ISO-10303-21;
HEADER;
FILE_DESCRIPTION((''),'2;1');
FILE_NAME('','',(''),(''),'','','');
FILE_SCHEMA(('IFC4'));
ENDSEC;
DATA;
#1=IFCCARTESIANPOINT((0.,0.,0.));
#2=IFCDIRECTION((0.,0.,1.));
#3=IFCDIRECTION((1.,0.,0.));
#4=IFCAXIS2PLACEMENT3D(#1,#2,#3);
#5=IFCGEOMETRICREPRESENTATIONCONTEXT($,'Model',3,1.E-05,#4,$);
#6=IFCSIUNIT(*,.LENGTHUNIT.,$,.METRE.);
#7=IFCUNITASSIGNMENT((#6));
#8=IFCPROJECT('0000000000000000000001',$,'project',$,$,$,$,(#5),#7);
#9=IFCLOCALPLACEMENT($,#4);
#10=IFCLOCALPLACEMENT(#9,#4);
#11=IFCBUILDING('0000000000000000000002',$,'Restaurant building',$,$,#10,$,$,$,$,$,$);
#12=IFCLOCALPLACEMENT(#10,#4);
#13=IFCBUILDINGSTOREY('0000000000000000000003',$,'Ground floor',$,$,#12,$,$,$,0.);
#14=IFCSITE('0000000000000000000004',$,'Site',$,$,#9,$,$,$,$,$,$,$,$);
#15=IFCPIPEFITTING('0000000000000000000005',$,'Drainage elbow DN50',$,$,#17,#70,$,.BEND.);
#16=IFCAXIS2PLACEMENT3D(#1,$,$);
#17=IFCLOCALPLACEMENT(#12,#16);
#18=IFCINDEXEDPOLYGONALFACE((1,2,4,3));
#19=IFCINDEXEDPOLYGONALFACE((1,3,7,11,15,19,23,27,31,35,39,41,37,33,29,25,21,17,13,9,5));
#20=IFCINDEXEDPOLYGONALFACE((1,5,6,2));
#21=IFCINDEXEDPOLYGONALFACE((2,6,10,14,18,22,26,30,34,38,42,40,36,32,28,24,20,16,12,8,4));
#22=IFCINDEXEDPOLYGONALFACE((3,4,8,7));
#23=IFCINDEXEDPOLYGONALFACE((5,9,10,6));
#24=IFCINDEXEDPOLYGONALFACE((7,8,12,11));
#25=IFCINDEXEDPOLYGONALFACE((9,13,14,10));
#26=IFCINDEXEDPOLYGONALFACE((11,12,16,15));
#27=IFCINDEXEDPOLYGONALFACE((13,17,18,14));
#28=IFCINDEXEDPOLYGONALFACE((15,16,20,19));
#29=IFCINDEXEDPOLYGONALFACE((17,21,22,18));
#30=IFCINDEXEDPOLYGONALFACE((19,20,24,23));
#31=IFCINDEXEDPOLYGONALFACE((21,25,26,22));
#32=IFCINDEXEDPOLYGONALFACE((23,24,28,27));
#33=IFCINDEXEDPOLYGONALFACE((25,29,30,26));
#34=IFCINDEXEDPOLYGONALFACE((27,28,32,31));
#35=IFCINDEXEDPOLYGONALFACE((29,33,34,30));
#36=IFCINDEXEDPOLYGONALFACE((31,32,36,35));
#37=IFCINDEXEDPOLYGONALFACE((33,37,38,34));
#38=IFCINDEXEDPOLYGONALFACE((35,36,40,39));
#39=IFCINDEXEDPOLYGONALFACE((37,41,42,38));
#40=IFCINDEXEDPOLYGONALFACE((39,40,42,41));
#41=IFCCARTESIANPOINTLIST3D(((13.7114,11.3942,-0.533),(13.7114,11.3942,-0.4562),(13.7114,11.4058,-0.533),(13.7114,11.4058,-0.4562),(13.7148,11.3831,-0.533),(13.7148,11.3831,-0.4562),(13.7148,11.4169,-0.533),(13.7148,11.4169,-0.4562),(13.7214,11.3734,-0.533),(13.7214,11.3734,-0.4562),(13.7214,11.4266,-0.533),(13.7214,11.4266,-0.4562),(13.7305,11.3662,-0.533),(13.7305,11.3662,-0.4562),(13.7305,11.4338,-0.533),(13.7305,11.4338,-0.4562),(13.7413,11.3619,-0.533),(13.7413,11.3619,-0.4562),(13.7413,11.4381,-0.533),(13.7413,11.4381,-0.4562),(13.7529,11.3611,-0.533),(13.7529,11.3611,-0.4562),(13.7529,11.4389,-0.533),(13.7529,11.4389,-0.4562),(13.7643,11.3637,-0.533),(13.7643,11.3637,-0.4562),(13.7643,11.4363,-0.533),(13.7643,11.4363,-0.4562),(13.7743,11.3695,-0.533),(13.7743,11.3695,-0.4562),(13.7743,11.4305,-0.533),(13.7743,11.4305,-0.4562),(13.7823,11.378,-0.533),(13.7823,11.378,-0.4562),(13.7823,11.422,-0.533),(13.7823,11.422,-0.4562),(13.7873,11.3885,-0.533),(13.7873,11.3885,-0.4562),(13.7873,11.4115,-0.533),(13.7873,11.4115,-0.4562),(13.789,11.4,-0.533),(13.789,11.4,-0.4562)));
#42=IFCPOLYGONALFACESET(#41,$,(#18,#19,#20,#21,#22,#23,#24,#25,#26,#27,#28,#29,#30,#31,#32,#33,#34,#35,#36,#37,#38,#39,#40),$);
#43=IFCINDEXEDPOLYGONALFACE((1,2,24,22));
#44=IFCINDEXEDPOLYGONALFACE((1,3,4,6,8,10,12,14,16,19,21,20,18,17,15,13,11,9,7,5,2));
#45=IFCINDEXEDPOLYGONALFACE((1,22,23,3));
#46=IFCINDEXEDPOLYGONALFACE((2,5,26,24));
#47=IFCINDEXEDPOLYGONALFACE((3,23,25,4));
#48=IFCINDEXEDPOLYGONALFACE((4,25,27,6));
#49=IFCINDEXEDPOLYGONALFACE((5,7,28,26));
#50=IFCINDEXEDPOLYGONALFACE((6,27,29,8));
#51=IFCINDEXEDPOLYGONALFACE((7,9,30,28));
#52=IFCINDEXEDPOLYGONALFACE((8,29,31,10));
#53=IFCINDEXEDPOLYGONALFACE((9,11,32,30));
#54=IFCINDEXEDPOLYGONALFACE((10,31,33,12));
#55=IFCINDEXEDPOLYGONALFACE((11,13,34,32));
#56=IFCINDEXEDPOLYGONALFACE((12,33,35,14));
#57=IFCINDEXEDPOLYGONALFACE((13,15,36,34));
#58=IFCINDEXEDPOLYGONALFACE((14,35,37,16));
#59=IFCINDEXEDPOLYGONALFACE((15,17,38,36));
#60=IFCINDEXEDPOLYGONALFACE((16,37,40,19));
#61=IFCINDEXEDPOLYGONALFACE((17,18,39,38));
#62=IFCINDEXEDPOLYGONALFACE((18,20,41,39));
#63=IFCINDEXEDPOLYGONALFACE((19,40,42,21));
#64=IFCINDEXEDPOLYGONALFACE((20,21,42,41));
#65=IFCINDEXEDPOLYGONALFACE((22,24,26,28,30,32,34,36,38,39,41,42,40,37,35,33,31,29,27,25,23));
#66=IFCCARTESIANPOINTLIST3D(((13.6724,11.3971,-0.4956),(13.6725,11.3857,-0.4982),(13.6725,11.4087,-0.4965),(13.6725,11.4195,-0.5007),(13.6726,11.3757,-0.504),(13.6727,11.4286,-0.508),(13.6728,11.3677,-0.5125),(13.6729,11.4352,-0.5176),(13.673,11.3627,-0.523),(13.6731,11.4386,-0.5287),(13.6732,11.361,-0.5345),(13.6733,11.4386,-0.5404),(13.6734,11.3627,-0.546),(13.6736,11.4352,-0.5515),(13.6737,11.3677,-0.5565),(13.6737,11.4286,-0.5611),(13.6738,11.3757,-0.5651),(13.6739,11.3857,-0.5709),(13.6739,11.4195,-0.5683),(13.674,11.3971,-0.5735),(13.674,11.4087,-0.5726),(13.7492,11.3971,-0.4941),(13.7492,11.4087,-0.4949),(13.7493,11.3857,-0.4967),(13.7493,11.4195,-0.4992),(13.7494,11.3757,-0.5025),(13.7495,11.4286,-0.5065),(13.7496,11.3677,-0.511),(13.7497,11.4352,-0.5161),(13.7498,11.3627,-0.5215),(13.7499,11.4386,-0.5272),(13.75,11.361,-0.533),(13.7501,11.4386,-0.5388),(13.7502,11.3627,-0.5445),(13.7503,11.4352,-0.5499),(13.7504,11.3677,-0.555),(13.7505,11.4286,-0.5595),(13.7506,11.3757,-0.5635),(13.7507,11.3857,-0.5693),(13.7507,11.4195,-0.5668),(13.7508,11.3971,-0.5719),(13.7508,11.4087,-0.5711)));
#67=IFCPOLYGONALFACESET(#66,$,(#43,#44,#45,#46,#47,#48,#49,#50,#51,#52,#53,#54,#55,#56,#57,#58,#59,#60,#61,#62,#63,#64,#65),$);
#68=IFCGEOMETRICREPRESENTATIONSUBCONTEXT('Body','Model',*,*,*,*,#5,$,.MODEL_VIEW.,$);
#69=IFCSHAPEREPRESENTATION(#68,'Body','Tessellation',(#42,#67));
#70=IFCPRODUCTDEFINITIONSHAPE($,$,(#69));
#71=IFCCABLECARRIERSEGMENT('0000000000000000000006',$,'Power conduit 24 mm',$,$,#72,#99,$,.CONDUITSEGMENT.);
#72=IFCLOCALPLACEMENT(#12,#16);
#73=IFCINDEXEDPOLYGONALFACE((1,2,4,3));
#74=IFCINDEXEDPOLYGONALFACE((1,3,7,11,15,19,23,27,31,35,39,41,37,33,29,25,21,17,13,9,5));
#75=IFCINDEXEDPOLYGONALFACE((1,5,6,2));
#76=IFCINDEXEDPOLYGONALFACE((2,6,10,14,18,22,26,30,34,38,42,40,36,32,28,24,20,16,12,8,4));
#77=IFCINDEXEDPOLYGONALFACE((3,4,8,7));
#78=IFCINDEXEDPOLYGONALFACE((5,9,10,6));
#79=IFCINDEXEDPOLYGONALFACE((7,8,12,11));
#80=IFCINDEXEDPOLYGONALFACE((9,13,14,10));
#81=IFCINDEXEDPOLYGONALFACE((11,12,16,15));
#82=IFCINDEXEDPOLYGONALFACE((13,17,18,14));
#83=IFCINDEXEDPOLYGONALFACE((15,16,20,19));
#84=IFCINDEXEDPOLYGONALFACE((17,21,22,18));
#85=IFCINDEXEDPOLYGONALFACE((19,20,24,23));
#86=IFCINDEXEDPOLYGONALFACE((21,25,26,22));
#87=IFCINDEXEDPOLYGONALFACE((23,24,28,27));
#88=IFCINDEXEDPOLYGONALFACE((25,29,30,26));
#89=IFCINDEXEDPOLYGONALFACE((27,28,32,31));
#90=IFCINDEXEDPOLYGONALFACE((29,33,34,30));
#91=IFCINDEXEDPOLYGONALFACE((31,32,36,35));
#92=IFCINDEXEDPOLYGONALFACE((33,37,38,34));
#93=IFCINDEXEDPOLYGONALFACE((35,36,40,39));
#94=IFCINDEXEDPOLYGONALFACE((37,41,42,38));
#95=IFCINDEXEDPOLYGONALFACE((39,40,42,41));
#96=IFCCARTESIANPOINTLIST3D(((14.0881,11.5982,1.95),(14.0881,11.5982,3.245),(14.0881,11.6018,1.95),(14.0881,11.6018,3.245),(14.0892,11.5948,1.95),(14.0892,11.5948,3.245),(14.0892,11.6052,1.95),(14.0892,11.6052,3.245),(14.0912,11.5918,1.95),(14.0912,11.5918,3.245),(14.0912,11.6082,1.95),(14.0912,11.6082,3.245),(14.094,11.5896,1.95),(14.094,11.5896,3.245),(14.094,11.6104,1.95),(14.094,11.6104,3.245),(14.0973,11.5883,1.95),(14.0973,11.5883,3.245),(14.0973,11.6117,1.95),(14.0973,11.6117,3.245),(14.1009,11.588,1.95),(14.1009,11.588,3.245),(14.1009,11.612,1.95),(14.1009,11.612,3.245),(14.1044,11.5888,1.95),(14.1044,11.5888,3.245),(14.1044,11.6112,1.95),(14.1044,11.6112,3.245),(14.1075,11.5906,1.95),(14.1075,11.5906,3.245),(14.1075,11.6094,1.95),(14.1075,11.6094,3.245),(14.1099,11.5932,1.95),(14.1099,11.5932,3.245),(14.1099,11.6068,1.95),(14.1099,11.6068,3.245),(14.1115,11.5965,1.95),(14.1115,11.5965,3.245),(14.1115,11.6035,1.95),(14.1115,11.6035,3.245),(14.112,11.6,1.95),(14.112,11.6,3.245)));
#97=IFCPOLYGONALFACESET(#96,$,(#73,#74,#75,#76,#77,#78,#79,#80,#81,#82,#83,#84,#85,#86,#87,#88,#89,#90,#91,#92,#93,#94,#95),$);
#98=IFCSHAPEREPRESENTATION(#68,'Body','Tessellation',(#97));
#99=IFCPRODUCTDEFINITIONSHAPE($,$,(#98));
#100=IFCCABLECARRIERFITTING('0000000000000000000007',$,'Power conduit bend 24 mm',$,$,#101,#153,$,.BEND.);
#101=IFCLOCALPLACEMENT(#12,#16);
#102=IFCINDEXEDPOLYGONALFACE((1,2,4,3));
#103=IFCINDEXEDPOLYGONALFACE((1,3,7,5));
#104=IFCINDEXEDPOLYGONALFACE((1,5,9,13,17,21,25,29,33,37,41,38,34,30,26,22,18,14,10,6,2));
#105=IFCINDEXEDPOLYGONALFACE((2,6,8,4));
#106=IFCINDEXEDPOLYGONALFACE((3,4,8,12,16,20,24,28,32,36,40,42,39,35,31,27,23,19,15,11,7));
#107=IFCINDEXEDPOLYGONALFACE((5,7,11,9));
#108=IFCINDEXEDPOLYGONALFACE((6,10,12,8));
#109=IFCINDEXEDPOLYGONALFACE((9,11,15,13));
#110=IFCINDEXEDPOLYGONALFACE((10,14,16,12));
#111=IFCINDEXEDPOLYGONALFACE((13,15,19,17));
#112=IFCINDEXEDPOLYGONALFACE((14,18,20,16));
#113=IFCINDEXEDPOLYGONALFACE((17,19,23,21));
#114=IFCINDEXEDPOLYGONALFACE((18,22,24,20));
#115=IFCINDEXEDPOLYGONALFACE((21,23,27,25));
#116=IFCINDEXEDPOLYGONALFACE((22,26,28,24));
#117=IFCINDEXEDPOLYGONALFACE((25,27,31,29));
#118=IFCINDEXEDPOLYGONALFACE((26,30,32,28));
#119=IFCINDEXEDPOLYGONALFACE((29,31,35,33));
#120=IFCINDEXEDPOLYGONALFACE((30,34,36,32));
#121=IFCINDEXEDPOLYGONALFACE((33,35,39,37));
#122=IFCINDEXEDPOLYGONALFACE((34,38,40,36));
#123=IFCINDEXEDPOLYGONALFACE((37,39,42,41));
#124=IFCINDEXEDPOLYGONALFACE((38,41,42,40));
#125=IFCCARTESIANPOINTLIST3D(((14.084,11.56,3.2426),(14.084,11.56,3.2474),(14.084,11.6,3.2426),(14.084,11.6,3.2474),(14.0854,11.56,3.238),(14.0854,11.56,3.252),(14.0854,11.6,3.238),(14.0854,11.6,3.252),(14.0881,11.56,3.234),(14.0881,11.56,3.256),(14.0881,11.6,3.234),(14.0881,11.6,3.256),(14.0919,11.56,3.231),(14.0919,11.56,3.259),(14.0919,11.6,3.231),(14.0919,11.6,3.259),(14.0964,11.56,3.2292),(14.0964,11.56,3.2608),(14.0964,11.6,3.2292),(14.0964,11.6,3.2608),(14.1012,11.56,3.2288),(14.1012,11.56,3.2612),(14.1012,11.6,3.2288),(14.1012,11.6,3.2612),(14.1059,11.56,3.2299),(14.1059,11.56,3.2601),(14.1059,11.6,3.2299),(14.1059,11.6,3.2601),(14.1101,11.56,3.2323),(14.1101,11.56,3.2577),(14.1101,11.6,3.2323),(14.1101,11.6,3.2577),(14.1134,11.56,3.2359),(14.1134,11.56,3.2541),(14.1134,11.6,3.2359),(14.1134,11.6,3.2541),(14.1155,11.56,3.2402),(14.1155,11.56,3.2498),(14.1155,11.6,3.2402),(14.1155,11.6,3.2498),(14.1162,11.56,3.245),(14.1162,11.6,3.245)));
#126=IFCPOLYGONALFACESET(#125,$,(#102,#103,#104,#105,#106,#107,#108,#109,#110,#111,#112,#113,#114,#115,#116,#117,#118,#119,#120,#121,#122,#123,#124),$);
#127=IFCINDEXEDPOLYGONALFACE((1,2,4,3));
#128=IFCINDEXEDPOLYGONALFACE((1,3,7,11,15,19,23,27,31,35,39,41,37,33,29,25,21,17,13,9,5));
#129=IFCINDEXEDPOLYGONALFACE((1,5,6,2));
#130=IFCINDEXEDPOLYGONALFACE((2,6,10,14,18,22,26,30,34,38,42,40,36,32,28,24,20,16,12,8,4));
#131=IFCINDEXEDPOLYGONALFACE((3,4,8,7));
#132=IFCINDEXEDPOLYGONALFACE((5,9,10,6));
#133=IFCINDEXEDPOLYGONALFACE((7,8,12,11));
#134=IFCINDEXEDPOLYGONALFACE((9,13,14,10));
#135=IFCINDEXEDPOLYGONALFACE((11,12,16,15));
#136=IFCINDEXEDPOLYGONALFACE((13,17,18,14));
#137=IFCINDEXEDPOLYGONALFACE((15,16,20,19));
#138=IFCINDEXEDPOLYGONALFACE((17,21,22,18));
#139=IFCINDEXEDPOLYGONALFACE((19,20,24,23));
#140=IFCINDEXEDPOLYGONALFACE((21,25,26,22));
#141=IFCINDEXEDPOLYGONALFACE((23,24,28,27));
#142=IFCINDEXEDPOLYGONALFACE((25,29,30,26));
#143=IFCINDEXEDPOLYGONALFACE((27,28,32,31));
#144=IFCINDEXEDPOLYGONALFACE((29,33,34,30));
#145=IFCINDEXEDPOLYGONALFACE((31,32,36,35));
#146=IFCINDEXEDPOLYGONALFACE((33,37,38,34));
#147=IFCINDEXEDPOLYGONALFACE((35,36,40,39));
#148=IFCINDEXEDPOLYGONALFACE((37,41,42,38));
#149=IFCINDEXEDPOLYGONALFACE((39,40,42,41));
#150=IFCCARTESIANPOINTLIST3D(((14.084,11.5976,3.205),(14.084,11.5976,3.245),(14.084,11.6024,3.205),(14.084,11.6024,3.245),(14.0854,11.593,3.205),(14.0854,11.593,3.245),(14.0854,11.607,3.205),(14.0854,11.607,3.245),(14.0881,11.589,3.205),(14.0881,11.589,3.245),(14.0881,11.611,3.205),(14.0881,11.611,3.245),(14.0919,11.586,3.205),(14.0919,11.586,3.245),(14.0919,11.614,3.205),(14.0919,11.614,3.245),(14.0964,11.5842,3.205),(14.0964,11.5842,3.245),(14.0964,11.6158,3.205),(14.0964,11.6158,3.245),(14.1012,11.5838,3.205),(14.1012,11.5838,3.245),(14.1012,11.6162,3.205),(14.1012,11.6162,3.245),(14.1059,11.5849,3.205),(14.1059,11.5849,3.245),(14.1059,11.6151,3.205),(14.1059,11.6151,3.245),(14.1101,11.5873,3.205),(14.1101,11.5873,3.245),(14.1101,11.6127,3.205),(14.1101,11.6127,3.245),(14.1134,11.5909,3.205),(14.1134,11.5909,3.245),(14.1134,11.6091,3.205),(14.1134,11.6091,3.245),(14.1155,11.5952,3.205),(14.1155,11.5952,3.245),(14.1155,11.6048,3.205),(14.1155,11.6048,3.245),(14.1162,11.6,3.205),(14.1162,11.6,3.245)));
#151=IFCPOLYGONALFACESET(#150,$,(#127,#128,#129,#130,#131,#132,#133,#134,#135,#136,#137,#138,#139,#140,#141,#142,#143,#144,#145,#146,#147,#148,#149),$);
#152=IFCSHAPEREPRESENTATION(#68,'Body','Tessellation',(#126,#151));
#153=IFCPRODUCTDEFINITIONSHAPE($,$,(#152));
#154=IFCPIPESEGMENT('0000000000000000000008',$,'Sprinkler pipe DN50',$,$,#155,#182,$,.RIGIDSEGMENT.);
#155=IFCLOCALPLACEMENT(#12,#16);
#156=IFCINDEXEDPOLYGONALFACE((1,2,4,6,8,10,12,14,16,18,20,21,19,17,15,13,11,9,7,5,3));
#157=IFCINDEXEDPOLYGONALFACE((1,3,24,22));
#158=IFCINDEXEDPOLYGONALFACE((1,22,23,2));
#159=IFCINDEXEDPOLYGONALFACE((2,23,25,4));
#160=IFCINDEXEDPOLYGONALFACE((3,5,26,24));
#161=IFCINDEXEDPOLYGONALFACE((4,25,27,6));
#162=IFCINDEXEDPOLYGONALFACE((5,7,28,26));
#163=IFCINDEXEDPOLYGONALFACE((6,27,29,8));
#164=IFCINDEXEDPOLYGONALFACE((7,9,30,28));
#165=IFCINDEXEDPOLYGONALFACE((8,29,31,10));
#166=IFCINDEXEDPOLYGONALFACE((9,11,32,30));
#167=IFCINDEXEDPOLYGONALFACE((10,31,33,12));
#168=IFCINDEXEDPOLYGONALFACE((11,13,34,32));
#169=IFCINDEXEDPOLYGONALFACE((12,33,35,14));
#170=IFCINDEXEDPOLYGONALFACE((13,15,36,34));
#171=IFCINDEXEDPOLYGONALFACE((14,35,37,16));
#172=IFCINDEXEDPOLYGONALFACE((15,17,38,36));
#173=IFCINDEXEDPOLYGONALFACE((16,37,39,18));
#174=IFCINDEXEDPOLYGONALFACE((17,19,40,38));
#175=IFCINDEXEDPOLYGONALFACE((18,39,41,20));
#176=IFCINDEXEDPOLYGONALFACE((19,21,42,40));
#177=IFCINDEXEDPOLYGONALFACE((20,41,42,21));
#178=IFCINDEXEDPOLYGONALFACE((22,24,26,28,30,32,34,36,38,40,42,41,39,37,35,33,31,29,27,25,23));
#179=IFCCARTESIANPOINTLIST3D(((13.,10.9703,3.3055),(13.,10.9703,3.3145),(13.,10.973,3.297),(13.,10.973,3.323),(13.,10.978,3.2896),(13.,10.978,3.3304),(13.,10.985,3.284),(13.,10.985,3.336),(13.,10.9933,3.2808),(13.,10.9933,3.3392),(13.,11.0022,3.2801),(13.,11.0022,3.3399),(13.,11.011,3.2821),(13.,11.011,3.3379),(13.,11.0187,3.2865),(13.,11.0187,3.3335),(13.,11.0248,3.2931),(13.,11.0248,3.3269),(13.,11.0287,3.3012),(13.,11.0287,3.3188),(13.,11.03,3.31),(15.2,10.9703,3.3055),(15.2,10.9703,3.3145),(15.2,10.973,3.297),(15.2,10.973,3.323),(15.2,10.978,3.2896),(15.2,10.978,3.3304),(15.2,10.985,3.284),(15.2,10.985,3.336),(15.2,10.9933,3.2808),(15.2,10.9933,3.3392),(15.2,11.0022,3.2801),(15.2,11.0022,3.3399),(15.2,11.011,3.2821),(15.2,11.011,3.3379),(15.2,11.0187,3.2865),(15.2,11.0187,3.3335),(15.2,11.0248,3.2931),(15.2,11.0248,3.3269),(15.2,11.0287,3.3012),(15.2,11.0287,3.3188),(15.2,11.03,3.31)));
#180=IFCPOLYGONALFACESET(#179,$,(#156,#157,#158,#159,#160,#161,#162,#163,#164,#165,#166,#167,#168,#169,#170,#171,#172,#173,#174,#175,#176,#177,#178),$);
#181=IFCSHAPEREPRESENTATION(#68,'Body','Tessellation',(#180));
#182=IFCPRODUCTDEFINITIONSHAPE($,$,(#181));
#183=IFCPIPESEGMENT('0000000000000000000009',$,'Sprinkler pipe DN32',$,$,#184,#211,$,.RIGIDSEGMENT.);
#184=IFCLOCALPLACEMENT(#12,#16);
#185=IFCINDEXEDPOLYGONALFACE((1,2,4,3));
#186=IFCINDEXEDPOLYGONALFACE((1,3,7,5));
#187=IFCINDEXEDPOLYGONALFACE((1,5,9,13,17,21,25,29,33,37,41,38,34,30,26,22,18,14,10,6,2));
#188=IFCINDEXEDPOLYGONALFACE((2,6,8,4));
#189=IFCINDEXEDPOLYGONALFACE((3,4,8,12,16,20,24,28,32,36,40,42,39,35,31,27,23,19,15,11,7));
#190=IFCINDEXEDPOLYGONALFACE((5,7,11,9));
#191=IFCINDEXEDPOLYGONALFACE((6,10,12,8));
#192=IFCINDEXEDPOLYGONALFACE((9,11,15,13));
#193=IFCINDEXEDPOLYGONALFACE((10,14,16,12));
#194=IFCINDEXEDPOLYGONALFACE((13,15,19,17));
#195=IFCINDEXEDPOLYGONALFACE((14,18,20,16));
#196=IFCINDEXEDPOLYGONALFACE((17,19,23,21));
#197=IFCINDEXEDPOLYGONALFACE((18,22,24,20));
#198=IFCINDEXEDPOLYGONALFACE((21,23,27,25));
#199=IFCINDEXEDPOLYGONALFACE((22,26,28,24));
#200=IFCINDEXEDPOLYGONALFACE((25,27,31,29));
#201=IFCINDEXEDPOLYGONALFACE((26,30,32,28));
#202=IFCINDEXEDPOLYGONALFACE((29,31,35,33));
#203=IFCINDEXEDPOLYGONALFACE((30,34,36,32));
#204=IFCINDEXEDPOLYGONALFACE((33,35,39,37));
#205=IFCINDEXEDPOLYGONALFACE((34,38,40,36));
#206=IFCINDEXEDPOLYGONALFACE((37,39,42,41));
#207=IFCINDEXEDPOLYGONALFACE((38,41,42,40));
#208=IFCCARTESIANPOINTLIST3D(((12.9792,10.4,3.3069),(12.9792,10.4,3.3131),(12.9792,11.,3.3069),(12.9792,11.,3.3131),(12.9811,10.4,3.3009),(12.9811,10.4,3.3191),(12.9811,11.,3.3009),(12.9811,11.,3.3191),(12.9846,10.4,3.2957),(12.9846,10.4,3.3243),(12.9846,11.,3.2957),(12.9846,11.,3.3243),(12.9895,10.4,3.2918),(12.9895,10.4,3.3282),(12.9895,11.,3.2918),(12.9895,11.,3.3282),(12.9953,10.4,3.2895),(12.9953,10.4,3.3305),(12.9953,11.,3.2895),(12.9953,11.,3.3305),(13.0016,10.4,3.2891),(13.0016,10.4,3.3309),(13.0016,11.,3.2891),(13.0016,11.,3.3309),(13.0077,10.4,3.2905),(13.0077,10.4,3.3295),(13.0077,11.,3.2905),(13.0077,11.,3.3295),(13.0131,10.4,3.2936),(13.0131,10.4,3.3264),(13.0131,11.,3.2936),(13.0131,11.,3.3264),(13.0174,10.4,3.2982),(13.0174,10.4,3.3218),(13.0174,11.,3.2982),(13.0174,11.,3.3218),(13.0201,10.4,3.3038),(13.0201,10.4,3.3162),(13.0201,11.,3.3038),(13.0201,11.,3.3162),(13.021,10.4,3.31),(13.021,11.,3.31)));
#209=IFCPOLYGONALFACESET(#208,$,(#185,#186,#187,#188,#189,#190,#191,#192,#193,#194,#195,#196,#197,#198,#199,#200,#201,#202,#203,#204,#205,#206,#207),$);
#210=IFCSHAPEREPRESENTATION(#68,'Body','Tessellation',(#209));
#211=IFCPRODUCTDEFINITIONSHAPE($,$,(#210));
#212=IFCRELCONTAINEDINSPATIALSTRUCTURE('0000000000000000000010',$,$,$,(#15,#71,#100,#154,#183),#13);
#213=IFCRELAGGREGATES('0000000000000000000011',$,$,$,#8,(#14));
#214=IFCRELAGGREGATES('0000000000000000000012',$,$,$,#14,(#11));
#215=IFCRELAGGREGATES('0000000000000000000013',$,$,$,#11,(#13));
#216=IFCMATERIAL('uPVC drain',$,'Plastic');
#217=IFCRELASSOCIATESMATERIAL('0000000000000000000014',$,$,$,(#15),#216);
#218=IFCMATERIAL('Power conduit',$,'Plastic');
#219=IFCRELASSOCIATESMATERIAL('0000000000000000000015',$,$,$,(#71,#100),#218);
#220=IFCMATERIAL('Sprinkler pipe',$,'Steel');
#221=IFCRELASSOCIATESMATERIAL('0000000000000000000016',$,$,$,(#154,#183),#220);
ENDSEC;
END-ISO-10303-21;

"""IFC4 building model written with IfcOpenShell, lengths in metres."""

from ifc_helpers import new_model, si_unit, frame, origin, origin_with_axes, origin_2d, place, context, subcontext, project, spatial, circle, extrude, material, element, save


model = new_model("IFC4")

# Units and contexts
model_context = context("Model", 3, precision=1e-05, world=origin_with_axes())
body_context = subcontext(model_context, "Body", "Model", "MODEL_VIEW")
ifc_project = project(units=[si_unit("LENGTHUNIT", "METRE")], contexts=[model_context])

# Site, building, storey
site_placement = place(None, origin_with_axes())
site = spatial("IfcSite", under=ifc_project, at=site_placement, Name="Site")
building_placement = place(site_placement, origin_with_axes())
building = spatial("IfcBuilding", under=site, at=building_placement, Name="Restaurant building")
storey_placement = place(building_placement, origin_with_axes())
storey = spatial("IfcBuildingStorey", under=building, at=storey_placement, Name="Ground floor", Elevation=0.0)

# Shared definitions
ifc_material_1 = material(Name="uPVC drain", Category="Plastic")

# Pipe fitting
pipe_fitting_1_placement = place(storey_placement, frame((13.75, 11.4, -0.533)))
element("IfcPipeFitting", 1, at=pipe_fitting_1_placement, inside=storey, material=ifc_material_1, Name="Drainage elbow DN50", PredefinedType="BEND", context=body_context, shape_type="SweptSolid", body=[
    extrude(circle(Radius=0.039, at=origin_2d()), origin(), (0.0, 0.0, 1.0), 0.0768),
    extrude(circle(Radius=0.039, at=origin_2d()), frame((0.0, 0.0, 0.0), z_axis=(-0.9998, 0.0, -0.019996), x_axis=(0.0, -1.0, 0.0)), (0.0, 0.0, 1.0), 0.0768),
])

# Cable carrier segment
ifc_material_2 = material(Name="Power conduit", Category="Plastic")
cable_carrier_segment_placement = place(storey_placement, frame((14.1, 11.6, 3.245)))
element("IfcCableCarrierSegment", 2, at=cable_carrier_segment_placement, inside=storey, material=ifc_material_2, Name="Power conduit 24 mm", PredefinedType="CONDUITSEGMENT", context=body_context, shape_type="SweptSolid", body=[
    extrude(circle(Radius=0.012, at=origin_2d()), frame((0.0, 0.0, 0.0), z_axis=(0.0, 0.0, -1.0), x_axis=(1.0, 0.0, 0.0)), (0.0, 0.0, 1.0), 1.295),
])

# Cable carrier fitting
cable_carrier_fitting_placement = place(storey_placement, frame((14.1, 11.6, 3.245)))
element("IfcCableCarrierFitting", 3, at=cable_carrier_fitting_placement, inside=storey, material=ifc_material_2, Name="Power conduit bend 24 mm", PredefinedType="BEND", context=body_context, shape_type="SweptSolid", body=[
    extrude(circle(Radius=0.0162, at=origin_2d()), frame((0.0, 0.0, 0.0), z_axis=(0.0, -1.0, 0.0), x_axis=(1.0, 0.0, 0.0)), (0.0, 0.0, 1.0), 0.04),
    extrude(circle(Radius=0.0162, at=origin_2d()), frame((0.0, 0.0, 0.0), z_axis=(0.0, 0.0, -1.0), x_axis=(1.0, 0.0, 0.0)), (0.0, 0.0, 1.0), 0.04),
])

# Pipe segments
ifc_material_3 = material(Name="Sprinkler pipe", Category="Steel")
pipe_segment_1_placement = place(storey_placement, frame((13.0, 11.0, 3.31)))
element("IfcPipeSegment", 4, at=pipe_segment_1_placement, inside=storey, material=ifc_material_3, Name="Sprinkler pipe DN50", PredefinedType="RIGIDSEGMENT", context=body_context, shape_type="SweptSolid", body=[
    extrude(circle(Radius=0.03, at=origin_2d()), frame((0.0, 0.0, 0.0), z_axis=(1.0, 0.0, 0.0), x_axis=(0.0, 1.0, 0.0)), (0.0, 0.0, 1.0), 2.2),
])
pipe_segment_2_placement = place(storey_placement, frame((13.0, 11.0, 3.31)))
element("IfcPipeSegment", 5, at=pipe_segment_2_placement, inside=storey, material=ifc_material_3, Name="Sprinkler pipe DN32", PredefinedType="RIGIDSEGMENT", context=body_context, shape_type="SweptSolid", body=[
    extrude(circle(Radius=0.021, at=origin_2d()), frame((0.0, 0.0, 0.0), z_axis=(0.0, -1.0, 0.0), x_axis=(1.0, 0.0, 0.0)), (0.0, 0.0, 1.0), 0.6),
])

save(model, "model.ifc")
